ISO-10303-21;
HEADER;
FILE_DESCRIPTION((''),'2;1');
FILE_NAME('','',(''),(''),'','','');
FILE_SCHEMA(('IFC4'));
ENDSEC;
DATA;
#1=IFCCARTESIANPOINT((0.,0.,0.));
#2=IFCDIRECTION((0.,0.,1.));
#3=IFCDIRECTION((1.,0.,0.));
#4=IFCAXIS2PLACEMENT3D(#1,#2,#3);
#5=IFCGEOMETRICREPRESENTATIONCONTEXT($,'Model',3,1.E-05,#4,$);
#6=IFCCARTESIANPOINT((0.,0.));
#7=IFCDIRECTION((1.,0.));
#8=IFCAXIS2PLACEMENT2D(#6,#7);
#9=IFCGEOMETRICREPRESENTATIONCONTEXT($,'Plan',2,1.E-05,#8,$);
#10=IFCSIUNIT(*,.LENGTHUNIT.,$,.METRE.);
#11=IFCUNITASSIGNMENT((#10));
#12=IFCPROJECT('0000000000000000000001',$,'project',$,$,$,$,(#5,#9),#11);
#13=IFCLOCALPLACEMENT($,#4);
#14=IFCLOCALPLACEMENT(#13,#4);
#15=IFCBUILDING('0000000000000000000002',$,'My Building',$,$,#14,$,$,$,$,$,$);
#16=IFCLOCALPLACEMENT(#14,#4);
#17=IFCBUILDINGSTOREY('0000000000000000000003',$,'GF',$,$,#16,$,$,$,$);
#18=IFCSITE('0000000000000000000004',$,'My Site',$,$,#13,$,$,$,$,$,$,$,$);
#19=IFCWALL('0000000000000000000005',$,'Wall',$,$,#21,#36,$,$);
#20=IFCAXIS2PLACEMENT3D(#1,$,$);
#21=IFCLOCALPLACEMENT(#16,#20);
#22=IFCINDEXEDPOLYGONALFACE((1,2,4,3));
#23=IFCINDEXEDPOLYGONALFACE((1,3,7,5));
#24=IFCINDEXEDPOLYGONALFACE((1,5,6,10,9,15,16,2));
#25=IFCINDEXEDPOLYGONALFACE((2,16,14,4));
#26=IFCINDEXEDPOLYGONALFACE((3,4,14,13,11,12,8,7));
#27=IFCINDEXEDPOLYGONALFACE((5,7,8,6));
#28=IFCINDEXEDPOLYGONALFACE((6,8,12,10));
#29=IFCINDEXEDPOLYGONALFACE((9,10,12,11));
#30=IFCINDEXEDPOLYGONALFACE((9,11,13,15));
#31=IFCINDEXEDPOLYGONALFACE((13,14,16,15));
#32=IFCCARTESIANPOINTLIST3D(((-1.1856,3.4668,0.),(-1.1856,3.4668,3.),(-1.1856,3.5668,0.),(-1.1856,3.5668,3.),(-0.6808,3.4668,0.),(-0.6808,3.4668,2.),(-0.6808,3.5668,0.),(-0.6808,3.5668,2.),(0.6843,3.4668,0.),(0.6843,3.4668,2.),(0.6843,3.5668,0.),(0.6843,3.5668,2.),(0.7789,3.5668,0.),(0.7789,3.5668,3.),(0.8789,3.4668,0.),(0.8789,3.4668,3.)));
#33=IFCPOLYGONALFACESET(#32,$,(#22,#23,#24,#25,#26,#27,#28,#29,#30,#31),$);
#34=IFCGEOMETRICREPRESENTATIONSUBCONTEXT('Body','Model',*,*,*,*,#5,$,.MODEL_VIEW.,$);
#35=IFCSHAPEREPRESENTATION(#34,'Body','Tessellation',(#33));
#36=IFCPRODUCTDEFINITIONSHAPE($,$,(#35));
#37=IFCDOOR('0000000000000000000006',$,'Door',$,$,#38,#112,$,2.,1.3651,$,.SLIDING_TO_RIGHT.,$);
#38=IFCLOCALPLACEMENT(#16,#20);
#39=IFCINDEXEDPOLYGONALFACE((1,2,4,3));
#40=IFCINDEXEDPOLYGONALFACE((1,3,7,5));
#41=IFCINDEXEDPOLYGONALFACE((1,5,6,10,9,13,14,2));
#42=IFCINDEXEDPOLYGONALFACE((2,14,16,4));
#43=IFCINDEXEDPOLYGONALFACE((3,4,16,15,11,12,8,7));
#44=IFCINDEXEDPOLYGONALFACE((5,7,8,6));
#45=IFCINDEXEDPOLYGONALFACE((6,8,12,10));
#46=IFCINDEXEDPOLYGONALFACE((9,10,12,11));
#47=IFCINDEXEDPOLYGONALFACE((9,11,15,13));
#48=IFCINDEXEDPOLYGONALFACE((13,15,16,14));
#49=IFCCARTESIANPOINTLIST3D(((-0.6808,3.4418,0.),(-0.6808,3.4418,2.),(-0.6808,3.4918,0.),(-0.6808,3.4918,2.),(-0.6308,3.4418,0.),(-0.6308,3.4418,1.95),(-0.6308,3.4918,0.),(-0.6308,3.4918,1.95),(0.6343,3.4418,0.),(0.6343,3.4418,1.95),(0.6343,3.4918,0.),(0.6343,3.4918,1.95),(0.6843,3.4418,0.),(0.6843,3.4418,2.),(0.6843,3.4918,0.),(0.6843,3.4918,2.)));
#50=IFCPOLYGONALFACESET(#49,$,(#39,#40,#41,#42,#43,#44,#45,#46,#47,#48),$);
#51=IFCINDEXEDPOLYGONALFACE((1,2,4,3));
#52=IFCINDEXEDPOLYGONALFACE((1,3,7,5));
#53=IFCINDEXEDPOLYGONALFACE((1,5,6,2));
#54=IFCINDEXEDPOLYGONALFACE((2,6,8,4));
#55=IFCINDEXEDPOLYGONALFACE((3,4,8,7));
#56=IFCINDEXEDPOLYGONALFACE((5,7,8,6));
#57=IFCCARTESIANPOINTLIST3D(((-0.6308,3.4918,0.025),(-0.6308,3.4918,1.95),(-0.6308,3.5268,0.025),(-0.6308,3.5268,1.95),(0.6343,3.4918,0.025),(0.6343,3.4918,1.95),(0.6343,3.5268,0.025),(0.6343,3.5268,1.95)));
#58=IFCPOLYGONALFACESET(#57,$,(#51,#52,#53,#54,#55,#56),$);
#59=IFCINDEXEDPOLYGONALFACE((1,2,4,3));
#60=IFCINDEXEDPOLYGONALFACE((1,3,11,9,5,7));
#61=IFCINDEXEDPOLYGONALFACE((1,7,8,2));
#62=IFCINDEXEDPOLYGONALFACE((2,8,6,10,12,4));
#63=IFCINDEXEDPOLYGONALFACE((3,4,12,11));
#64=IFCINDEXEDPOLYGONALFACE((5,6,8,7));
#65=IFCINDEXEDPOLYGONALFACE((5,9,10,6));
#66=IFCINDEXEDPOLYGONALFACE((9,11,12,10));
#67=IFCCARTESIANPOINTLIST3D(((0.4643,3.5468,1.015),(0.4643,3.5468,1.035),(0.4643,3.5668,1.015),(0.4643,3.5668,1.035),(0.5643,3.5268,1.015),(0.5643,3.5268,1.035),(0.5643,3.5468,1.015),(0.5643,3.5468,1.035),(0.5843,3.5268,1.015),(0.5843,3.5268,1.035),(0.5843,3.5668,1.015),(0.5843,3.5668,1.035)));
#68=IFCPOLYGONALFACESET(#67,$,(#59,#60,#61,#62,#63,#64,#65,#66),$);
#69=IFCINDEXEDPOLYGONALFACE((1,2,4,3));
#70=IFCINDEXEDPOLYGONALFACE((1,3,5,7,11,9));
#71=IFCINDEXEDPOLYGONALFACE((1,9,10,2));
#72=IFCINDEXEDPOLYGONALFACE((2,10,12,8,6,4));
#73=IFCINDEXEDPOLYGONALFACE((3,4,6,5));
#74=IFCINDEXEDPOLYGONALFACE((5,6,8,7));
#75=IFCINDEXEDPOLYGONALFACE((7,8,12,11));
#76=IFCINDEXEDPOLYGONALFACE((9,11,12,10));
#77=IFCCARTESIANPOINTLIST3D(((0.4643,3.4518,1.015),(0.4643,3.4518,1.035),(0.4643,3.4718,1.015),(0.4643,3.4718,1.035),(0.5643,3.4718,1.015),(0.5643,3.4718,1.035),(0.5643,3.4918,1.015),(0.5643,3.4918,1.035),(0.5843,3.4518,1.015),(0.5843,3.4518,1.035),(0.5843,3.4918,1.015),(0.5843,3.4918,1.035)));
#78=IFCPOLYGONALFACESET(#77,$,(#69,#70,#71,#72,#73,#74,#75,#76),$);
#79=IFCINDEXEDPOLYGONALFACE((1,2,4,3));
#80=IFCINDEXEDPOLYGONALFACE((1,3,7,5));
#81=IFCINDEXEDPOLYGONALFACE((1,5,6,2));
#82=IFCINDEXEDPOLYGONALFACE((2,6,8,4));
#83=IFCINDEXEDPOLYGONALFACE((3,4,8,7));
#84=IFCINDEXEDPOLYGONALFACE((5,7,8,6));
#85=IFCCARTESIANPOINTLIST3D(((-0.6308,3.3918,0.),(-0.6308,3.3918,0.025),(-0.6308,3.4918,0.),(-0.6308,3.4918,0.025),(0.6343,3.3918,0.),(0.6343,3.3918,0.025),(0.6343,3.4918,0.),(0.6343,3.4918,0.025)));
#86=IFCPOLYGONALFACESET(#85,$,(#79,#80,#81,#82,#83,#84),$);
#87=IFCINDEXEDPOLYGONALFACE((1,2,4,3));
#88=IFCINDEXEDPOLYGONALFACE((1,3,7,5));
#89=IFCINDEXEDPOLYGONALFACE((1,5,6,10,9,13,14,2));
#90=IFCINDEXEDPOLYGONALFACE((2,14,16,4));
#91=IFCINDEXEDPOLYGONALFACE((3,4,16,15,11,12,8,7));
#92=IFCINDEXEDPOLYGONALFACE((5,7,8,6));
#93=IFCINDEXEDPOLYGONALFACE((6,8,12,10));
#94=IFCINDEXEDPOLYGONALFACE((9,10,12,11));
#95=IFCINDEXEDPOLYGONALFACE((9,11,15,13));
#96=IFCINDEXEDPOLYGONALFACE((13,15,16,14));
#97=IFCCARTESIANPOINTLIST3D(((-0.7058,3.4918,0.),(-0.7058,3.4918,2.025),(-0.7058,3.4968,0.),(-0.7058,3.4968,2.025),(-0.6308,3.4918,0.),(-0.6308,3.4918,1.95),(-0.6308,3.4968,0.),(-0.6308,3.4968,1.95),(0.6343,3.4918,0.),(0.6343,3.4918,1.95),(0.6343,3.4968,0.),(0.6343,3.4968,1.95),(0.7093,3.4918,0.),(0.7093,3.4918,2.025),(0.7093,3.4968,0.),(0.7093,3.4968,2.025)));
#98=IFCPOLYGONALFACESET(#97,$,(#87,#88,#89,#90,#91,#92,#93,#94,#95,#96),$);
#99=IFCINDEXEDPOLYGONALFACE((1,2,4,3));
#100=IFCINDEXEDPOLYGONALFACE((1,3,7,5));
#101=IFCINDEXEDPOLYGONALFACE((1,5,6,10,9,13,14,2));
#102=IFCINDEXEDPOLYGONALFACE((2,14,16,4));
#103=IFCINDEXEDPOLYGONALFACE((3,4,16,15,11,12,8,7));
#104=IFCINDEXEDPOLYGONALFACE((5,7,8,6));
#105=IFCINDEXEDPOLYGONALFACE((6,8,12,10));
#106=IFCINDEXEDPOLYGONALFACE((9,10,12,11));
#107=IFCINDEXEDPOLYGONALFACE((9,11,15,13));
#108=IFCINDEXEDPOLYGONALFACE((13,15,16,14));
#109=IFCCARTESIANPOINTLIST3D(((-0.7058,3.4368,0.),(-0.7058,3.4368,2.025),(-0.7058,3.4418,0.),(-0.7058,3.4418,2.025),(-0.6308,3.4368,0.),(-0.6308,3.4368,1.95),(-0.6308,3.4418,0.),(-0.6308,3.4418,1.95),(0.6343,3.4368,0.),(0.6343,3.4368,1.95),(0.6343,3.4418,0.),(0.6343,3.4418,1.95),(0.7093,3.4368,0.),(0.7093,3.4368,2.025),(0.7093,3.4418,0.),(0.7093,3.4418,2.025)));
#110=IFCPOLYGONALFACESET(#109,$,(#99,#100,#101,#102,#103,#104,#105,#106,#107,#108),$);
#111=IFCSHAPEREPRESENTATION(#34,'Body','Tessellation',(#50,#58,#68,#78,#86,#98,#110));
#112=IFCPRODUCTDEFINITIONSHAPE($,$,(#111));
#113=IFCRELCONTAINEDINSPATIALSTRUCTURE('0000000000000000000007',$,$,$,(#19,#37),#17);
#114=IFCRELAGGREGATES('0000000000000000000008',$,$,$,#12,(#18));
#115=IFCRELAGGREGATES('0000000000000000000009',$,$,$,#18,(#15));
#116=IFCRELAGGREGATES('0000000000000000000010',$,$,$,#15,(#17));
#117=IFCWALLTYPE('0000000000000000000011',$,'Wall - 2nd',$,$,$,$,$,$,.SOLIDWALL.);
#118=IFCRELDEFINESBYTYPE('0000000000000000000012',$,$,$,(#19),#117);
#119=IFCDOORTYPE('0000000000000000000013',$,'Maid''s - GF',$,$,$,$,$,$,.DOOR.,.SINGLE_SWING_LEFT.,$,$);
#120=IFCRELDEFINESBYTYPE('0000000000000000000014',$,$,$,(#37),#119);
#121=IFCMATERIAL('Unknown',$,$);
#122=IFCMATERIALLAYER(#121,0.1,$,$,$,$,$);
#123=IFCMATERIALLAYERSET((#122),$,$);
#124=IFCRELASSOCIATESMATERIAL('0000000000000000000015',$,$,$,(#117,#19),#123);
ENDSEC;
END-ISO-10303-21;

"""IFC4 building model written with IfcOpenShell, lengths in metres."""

from ifc_helpers import new_model, entity, si_unit, frame, origin_with_axes, origin_2d_with_axis, place, context, subcontext, project, spatial, line, indexed_curve, outline, extrude, shape, source, transform, mapped, material, layer, layer_set, layer_usage, type_object, type_shapes, element, fill, save


model = new_model("IFC4")

# Units and contexts
model_context = context("Model", 3, precision=1e-05, world=origin_with_axes())
plan_context = context("Plan", 2, precision=1e-05, world=origin_2d_with_axis())
body_context_1 = subcontext(model_context, "Body", "Model", "MODEL_VIEW")
body_context_2 = subcontext(plan_context, "Body", "Plan", "PLAN_VIEW")
ifc_project = project(units=[si_unit("LENGTHUNIT", "METRE")], contexts=[model_context, plan_context])

# Site, building, storey
site_placement = place(None, origin_with_axes())
site = spatial("IfcSite", under=ifc_project, at=site_placement, Name="My Site")
building_placement = place(site_placement, origin_with_axes())
building = spatial("IfcBuilding", under=site, at=building_placement, Name="My Building")
storey_placement = place(building_placement, origin_with_axes())
storey = spatial("IfcBuildingStorey", under=building, at=storey_placement, Name="GF")

# Shared definitions
ifc_material = material(Name="Unknown")

# Shared definitions
ifc_layer_1 = layer(ifc_material, 0.1)
ifc_layer_set_1 = layer_set([ifc_layer_1])
wall_type = type_object("IfcWallType", Name="Wall - 2nd", PredefinedType="SOLIDWALL", material=ifc_layer_set_1)

# Wall, opening, door
ifc_layer_usage_1 = layer_usage(ifc_layer_set_1, "AXIS2", "POSITIVE", 0.0)
wall_1_placement = place(storey_placement, frame((0.7789, 3.5668, 0.0), z_axis=(0.0, 0.0, 1.0), x_axis=(-1.0, 0.0, 0.0)))
wall_1 = element("IfcWall", 1, at=wall_1_placement, inside=storey, type_object=wall_type, material=ifc_layer_usage_1, Name="Wall", context=body_context_1, shape_type="SweptSolid", body=[
    extrude(outline(indexed_curve([(0.0, 0.0), (-0.1, 0.1), (1.9645, 0.1), (1.9645, 0.0)], segments=[line(1, 2, 3, 4, 1)])), origin_with_axes(), (0.0, 0.0, 1.0), 3.0),
])
shared_shape_1 = source(origin_with_axes(), body_context_1, "Body", "SweptSolid", [
    extrude(outline(indexed_curve([(0.0, 0.0), (1.3651, 0.0), (1.3651, 2.0), (0.0, 2.0)], segments=[line(1, 2, 3, 4, 1)])), frame((0.0, -0.6, 0.0), z_axis=(0.0, -1.0, 0.0), x_axis=(1.0, 0.0, 0.0)), (0.0, 0.0, -1.0), 1.2),
])
opening_1_placement = place(wall_1_placement, frame((0.0946, 0.075, 0.0), z_axis=(0.0, 0.0, 1.0), x_axis=(1.0, -0.000001, 0.0)))
opening_1 = element("IfcOpeningElement", 2, at=opening_1_placement, cuts=wall_1, PredefinedType="OPENING", context=body_context_1, shape_type="MappedRepresentation", body=[
    mapped(shared_shape_1, transform((0.0, 0.0, 0.0), x_axis=(1.0, 0.0, 0.0), y_axis=(0.0, 1.0, 0.0), z_axis=(0.0, 0.0, 1.0), scale=1.0)),
])
door_type_1 = type_object("IfcDoorType", Name="Maid's - GF", OperationType="SINGLE_SWING_LEFT", PredefinedType="DOOR")
shared_shape_2 = source(origin_with_axes(), body_context_1, "Body", "SweptSolid", [
    extrude(outline(indexed_curve([(0.0, 0.0), (0.0, 2.0), (1.3651, 2.0), (1.3651, 0.0), (1.3151, 0.0), (1.3151, 1.95), (0.05, 1.95), (0.05, 0.0)], segments=[line(1, 2, 3, 4, 5, 6, 7, 8, 1)])), frame((0.0, 0.0, 0.0), z_axis=(0.0, -1.0, 0.0), x_axis=(1.0, 0.0, 0.0)), (0.0, 0.0, -1.0), 0.05),
    extrude(outline(indexed_curve([(0.0, 0.0), (1.2651, 0.0), (1.2651, 0.035), (0.0, 0.035)], segments=[line(1, 2, 3, 4, 1)])), frame((0.05, -0.035, 0.025), z_axis=(0.0, 0.0, 1.0), x_axis=(1.0, 0.0, 0.0)), (0.0, 0.0, 1.0), 1.925),
    extrude(outline(indexed_curve([(0.0, 0.0), (0.0, -0.04), (0.12, -0.04), (0.12, -0.02), (0.02, -0.02), (0.02, 0.0)], segments=[line(1, 2, 3, 4, 5, 6, 1)])), frame((0.1, -0.035, 1.015), z_axis=(0.0, 0.0, 1.0), x_axis=(1.0, 0.0, 0.0)), (0.0, 0.0, 1.0), 0.02),
    extrude(outline(indexed_curve([(0.0, 0.0), (0.0, 0.04), (0.12, 0.04), (0.12, 0.02), (0.02, 0.02), (0.02, 0.0)], segments=[line(1, 2, 3, 4, 5, 6, 1)])), frame((0.1, 0.0, 1.015), z_axis=(0.0, 0.0, 1.0), x_axis=(1.0, 0.0, 0.0)), (0.0, 0.0, 1.0), 0.02),
    extrude(outline(indexed_curve([(0.0, 0.0), (1.2651, 0.0), (1.2651, 0.1), (0.0, 0.1)], segments=[line(1, 2, 3, 4, 1)])), frame((0.05, 0.0, 0.0), z_axis=(0.0, 0.0, 1.0), x_axis=(1.0, 0.0, 0.0)), (0.0, 0.0, 1.0), 0.025),
    extrude(outline(indexed_curve([(0.0, 0.0), (0.0, 2.025), (1.4151, 2.025), (1.4151, 0.0), (1.3401, 0.0), (1.3401, 1.95), (0.075, 1.95), (0.075, 0.0)], segments=[line(1, 2, 3, 4, 5, 6, 7, 8, 1)])), frame((-0.025, -0.005, 0.0), z_axis=(0.0, -1.0, 0.0), x_axis=(1.0, 0.0, 0.0)), (0.0, 0.0, -1.0), 0.005),
    extrude(outline(indexed_curve([(0.0, 0.0), (0.0, 2.025), (1.4151, 2.025), (1.4151, 0.0), (1.3401, 0.0), (1.3401, 1.95), (0.075, 1.95), (0.075, 0.0)], segments=[line(1, 2, 3, 4, 5, 6, 7, 8, 1)])), frame((-0.025, 0.05, 0.0), z_axis=(0.0, -1.0, 0.0), x_axis=(1.0, 0.0, 0.0)), (0.0, 0.0, -1.0), 0.005),
])
shared_shape_3 = source(origin_with_axes(), body_context_2, "Body", "Curve2D", [
    entity("IfcIndexedPolyCurve", entity("IfcCartesianPointList2D", [[0.0, 0.0], [0.05, 0.0], [0.05, 0.05], [0.0, 0.05]]), [entity("IfcLineIndex", [1, 2, 3, 4, 1])]),
    entity("IfcIndexedPolyCurve", entity("IfcCartesianPointList2D", [[1.3651, 0.0], [1.3151, 0.0], [1.3151, 0.05], [1.3651, 0.05]]), [entity("IfcLineIndex", [1, 2, 3, 4, 1])]),
    entity("IfcIndexedPolyCurve", entity("IfcCartesianPointList2D", [[1.9477, -0.035], [0.6826, -0.035], [0.6826, 0.0], [1.9477, 0.0]]), [entity("IfcLineIndex", [1, 2, 3, 4, 1])]),
])
type_shapes(door_type_1, [shared_shape_2, shared_shape_3])
door_1_placement = place(opening_1_placement, frame((0.0, 0.0, 0.0), z_axis=(0.0, 0.0, 1.0), x_axis=(1.0, 0.0, 0.0)))
door_1 = element("IfcDoor", 3, at=door_1_placement, inside=storey, type_object=door_type_1, Name="Door", OperationType="SLIDING_TO_RIGHT", OverallHeight=2.0, OverallWidth=1.3651, shapes=[
    shape(body_context_1, "Body", "MappedRepresentation", [mapped(shared_shape_2, transform((0.0, 0.0, 0.0), x_axis=(1.0, 0.0, 0.0), y_axis=(0.0, 1.0, 0.0), z_axis=(0.0, 0.0, 1.0), scale=1.0))]),
    shape(body_context_2, "Body", "MappedRepresentation", [mapped(shared_shape_3, transform((0.0, 0.0, 0.0), x_axis=(1.0, 0.0, 0.0), y_axis=(0.0, 1.0, 0.0), z_axis=(0.0, 0.0, 1.0), scale=1.0))]),
])
fill(opening_1, door_1)

save(model, "model.ifc")
